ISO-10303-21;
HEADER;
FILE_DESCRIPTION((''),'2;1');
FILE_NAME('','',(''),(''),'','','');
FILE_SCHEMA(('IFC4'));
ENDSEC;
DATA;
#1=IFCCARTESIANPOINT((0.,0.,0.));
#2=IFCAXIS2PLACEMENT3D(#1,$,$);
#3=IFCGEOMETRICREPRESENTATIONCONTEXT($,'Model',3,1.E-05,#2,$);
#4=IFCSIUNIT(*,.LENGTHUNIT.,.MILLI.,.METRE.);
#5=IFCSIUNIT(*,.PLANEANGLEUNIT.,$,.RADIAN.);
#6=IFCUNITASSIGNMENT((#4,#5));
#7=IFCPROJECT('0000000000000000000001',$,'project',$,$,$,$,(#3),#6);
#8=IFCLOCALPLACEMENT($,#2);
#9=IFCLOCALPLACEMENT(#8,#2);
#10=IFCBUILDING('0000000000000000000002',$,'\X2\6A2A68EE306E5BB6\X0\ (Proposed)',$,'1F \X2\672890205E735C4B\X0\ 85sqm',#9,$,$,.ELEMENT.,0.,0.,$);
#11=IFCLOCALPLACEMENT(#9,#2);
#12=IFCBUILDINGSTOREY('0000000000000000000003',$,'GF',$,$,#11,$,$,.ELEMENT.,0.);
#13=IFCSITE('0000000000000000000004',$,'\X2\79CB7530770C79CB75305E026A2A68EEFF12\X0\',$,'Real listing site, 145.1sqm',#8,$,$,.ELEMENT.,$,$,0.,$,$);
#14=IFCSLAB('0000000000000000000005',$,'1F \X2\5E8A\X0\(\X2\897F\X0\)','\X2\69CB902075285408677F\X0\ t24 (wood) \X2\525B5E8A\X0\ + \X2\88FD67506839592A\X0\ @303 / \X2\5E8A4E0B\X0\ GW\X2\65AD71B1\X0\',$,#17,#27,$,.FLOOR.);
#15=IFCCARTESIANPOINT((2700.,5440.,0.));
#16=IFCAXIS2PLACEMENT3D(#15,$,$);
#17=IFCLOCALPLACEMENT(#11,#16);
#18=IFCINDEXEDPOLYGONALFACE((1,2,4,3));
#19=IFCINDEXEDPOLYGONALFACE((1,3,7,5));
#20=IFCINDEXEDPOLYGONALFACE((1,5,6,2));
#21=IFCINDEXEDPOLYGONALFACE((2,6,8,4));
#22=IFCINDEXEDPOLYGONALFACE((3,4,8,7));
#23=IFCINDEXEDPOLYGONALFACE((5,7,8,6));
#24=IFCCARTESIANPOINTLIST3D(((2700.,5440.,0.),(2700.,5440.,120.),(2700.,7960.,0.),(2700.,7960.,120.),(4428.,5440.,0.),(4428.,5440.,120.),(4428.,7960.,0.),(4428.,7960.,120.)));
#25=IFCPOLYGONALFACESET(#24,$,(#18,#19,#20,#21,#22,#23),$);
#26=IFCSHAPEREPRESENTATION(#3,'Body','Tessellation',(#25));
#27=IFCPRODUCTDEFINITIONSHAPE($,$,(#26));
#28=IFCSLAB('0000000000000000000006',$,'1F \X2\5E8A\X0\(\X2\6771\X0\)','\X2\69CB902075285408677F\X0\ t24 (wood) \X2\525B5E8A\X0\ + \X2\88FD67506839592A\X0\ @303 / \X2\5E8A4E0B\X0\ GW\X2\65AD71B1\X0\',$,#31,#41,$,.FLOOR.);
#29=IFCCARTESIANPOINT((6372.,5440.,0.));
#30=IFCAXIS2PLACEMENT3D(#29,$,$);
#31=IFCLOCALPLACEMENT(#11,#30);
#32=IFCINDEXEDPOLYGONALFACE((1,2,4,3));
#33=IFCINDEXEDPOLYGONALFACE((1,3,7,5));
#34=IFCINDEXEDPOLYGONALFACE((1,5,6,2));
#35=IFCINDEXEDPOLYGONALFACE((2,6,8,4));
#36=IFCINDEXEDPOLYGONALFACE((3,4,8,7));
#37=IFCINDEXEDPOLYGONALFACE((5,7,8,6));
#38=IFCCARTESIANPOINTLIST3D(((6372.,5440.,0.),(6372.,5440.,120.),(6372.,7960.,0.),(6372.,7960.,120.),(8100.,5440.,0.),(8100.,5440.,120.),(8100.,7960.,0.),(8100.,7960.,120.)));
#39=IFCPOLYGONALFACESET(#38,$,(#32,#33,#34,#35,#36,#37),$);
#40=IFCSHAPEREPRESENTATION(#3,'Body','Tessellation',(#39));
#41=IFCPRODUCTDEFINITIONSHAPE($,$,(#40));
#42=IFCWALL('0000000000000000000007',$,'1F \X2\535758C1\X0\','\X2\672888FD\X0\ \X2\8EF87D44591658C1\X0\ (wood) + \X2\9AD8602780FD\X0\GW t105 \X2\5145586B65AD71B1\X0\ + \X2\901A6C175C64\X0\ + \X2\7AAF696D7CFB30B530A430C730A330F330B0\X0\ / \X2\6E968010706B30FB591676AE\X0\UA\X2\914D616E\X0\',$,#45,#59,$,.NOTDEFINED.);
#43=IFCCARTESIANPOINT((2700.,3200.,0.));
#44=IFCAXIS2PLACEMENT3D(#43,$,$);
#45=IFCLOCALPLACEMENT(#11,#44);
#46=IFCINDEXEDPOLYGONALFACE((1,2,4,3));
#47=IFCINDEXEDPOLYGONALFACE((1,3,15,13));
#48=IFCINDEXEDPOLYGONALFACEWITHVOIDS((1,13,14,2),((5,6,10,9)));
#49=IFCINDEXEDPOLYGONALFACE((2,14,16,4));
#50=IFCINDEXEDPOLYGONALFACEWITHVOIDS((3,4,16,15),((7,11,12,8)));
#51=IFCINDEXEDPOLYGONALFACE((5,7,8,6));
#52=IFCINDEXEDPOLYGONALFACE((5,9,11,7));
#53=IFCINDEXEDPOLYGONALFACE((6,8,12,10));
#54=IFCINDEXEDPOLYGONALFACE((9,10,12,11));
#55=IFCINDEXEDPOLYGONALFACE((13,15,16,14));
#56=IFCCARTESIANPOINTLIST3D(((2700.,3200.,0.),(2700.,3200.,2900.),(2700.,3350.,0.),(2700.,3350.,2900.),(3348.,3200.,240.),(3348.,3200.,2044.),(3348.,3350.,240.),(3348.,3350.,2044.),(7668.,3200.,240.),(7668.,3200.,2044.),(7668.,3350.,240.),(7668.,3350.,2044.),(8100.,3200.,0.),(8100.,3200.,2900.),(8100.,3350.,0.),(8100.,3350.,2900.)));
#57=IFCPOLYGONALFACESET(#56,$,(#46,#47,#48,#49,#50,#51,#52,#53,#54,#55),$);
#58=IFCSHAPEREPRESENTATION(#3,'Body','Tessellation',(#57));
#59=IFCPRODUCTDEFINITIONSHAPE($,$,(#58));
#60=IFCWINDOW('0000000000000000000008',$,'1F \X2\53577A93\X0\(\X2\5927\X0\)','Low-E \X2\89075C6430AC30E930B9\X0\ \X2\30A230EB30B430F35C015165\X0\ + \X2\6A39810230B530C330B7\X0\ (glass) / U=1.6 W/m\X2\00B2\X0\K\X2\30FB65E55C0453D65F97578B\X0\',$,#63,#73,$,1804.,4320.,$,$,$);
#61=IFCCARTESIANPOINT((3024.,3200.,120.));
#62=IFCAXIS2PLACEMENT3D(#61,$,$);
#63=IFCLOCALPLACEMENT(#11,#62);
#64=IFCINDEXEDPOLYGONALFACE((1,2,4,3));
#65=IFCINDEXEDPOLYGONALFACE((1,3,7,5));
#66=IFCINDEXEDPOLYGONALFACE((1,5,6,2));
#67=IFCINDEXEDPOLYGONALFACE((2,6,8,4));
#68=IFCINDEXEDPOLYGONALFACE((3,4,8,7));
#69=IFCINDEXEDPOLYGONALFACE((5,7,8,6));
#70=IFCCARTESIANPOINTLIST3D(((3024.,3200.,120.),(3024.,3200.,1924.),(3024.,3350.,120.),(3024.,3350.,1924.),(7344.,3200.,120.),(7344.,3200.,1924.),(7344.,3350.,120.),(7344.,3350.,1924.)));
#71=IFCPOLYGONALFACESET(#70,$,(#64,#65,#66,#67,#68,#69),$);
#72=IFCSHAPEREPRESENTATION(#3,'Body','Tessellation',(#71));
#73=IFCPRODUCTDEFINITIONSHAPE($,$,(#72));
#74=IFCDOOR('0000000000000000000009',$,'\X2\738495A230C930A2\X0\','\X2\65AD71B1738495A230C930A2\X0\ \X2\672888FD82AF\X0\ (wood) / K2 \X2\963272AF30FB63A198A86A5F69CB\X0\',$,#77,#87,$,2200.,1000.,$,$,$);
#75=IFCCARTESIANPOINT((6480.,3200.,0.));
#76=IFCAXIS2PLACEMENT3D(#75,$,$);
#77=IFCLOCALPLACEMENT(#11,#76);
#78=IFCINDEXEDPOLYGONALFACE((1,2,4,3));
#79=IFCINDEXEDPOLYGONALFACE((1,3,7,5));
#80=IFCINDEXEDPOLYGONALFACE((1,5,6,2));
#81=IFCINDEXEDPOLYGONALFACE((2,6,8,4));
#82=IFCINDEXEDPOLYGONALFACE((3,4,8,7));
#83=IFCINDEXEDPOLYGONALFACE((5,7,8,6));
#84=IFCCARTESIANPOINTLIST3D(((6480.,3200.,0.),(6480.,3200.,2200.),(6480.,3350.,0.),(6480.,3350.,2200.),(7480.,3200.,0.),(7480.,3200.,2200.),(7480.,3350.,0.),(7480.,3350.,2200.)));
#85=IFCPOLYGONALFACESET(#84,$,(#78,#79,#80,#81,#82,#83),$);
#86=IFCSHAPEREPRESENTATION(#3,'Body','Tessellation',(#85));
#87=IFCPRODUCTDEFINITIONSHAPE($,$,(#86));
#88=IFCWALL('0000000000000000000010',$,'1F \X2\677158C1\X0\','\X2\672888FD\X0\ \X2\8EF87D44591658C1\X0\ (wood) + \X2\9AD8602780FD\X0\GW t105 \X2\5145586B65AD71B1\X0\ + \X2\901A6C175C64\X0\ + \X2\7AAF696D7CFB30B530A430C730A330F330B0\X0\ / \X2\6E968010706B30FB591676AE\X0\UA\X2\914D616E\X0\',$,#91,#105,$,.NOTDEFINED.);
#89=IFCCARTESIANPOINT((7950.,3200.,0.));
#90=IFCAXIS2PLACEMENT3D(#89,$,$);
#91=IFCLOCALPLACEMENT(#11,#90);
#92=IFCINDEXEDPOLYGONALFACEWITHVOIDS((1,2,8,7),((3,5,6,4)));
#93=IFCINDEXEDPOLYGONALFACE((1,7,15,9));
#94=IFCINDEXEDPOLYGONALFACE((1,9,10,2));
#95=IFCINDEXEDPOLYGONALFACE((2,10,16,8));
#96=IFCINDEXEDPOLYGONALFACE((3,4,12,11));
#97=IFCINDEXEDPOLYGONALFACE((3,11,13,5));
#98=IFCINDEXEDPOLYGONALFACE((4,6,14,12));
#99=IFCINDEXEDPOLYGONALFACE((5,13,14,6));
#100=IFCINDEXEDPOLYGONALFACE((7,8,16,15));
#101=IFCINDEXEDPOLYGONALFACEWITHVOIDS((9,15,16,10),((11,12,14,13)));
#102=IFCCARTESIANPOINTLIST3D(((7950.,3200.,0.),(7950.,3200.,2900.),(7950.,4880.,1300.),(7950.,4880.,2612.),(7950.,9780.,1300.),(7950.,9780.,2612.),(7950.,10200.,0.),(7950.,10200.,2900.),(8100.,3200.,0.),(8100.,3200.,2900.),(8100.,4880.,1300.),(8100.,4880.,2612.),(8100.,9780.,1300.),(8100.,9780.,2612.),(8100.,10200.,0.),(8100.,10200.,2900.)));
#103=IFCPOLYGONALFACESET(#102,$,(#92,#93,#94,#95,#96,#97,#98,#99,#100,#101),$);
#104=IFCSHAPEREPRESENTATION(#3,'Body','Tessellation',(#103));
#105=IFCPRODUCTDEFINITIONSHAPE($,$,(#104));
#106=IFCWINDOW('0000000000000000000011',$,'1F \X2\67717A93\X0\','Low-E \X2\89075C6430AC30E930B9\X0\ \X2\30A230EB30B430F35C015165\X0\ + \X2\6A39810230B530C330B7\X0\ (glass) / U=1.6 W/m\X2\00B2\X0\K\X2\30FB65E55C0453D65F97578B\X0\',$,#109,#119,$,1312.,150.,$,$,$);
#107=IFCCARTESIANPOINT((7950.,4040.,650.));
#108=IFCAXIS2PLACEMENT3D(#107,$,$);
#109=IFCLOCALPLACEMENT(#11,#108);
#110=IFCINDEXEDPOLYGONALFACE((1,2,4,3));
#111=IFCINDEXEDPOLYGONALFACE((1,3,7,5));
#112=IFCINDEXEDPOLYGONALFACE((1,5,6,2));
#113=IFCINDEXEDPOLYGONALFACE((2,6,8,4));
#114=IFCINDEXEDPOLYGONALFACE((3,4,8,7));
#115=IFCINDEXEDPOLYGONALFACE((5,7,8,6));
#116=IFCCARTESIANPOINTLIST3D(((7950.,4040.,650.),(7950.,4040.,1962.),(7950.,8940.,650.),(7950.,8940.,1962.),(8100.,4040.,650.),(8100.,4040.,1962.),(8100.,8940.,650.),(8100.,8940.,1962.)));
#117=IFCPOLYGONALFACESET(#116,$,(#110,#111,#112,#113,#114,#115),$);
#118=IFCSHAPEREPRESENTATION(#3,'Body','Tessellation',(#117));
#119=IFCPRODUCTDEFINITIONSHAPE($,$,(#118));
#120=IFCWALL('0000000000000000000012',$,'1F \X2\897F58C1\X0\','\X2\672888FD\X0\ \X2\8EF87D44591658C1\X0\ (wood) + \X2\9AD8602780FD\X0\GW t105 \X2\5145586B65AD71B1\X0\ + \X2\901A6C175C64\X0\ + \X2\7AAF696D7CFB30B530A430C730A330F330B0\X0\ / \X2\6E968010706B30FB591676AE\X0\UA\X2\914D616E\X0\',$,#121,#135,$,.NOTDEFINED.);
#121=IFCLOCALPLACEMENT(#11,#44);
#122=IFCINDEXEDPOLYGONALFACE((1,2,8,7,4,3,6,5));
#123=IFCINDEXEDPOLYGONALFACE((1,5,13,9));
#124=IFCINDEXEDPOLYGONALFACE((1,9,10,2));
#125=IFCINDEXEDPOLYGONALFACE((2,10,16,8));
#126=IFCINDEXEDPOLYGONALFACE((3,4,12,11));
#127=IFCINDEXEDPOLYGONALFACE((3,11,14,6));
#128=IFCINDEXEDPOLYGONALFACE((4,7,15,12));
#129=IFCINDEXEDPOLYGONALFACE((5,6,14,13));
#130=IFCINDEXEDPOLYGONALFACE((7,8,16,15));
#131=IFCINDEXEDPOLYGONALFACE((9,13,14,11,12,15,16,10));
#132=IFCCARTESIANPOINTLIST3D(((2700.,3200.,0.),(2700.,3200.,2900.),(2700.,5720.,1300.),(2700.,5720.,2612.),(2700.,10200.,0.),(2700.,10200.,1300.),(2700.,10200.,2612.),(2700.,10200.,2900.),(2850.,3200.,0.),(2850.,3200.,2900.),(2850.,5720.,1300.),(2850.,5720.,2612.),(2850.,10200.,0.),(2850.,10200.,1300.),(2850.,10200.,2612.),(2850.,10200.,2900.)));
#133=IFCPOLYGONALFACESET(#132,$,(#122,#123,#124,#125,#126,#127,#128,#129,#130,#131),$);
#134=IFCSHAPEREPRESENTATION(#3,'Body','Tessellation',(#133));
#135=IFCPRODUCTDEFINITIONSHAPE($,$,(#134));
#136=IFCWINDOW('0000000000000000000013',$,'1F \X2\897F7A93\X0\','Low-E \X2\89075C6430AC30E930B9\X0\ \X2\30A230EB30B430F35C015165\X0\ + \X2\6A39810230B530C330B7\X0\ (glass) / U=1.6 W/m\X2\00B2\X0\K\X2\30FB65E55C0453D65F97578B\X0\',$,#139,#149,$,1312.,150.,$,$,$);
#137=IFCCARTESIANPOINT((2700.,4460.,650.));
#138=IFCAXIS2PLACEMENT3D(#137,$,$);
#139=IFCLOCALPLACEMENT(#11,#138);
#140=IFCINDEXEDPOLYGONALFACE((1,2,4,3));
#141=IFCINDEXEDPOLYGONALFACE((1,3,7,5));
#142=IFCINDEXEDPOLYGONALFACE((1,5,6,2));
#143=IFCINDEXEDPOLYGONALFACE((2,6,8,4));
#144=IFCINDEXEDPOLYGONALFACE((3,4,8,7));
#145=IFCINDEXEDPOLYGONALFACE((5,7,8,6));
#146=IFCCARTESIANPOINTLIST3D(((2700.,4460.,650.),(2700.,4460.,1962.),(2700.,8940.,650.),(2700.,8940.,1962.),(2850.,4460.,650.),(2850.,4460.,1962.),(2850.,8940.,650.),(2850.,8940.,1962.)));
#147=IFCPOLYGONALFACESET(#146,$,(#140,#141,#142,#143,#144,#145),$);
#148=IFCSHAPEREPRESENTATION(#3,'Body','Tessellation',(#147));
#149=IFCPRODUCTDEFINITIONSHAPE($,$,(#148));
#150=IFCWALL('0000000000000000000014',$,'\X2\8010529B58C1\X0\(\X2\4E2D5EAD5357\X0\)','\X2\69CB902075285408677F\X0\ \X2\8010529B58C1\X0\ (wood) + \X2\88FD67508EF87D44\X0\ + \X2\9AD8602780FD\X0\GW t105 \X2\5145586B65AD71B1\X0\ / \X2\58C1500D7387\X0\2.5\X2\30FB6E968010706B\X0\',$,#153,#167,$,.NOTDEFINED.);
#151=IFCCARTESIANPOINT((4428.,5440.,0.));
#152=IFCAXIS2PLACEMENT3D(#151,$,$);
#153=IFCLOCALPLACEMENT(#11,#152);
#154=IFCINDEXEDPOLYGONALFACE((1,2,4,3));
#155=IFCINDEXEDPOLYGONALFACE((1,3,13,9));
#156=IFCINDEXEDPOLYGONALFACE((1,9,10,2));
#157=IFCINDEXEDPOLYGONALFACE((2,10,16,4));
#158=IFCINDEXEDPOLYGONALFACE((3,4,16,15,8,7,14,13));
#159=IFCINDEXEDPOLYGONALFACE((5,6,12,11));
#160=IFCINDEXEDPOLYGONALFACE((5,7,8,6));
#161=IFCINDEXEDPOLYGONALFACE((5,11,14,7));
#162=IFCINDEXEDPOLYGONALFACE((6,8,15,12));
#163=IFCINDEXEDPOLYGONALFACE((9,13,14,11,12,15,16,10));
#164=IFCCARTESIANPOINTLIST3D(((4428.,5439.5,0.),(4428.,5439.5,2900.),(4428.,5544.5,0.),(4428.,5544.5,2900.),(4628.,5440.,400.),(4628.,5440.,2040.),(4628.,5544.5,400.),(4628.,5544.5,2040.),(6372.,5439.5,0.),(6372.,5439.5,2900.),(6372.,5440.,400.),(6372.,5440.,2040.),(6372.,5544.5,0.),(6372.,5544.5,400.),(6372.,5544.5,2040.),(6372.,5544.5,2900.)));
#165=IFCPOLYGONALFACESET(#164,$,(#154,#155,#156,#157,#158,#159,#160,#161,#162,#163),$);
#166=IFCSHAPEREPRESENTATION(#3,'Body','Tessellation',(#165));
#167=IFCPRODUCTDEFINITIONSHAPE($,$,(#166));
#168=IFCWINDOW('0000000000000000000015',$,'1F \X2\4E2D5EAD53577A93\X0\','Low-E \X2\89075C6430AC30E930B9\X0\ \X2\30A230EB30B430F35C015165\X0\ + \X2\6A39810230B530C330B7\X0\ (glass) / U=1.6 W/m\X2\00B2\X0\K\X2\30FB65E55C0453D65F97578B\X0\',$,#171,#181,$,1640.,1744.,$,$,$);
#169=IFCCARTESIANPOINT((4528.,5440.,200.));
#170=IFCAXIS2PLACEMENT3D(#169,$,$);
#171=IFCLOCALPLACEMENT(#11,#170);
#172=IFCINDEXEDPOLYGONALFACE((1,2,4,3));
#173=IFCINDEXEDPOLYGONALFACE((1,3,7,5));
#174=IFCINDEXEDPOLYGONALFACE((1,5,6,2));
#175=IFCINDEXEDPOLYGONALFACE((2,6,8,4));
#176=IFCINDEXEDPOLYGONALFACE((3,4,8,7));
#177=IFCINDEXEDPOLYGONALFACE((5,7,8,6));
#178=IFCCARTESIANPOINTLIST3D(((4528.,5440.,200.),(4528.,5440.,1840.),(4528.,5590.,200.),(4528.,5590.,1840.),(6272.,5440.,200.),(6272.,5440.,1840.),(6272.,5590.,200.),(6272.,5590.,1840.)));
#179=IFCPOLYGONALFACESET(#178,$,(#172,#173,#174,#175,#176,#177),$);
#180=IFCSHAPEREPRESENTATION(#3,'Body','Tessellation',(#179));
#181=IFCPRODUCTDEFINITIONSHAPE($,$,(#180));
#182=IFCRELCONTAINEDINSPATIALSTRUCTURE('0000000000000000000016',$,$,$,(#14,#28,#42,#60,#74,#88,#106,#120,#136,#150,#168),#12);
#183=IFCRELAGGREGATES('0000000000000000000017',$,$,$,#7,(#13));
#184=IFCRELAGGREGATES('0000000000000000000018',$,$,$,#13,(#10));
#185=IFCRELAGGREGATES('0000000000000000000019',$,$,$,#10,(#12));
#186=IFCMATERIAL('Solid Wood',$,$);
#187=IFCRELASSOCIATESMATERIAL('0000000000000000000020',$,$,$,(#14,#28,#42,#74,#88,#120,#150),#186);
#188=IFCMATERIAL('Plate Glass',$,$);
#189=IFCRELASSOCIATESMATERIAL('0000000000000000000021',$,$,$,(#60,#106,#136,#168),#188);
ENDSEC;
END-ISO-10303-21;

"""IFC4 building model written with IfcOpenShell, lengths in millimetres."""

from ifc_helpers import new_model, si_unit, frame, frame_2d, origin, place, context, project, spatial, rectangle, extrude, material, element, fill, save


model = new_model("IFC4")

# Units and contexts
model_context = context("Model", 3, precision=1e-05, world=origin())
ifc_project = project(units=[si_unit("LENGTHUNIT", "METRE", prefix="MILLI"), si_unit("PLANEANGLEUNIT", "RADIAN")], contexts=[model_context])

# Site, building, storey
site_placement = place(None, origin())
site = spatial("IfcSite", under=ifc_project, at=site_placement, Name="秋田県秋田市横森２", ObjectType="Real listing site, 145.1sqm", CompositionType="ELEMENT", RefElevation=0.0)
building_placement = place(site_placement, origin())
building = spatial("IfcBuilding", under=site, at=building_placement, Name="横森の家 (Proposed)", ObjectType="1F 木造平屋 85sqm", CompositionType="ELEMENT", ElevationOfRefHeight=0.0, ElevationOfTerrain=0.0)
storey_placement = place(building_placement, origin())
storey = spatial("IfcBuildingStorey", under=building, at=storey_placement, Name="GF", CompositionType="ELEMENT", Elevation=0.0)

# Slabs
ifc_material_1 = material(Name="Solid Wood")
slab_1_placement = place(storey_placement, frame((2700.0, 5440.0, 0.0)))
element("IfcSlab", 1, at=slab_1_placement, inside=storey, material=ifc_material_1, Name="1F 床(西)", Description="構造用合板 t24 (wood) 剛床 + 製材根太 @303 / 床下 GW断熱", PredefinedType="FLOOR", context=model_context, shape_type="SweptSolid", body=[
    extrude(rectangle(XDim=1728.0, YDim=2520.0, at=frame_2d((864.0, 1260.0))), frame((2700.0, 5440.0, 0.0)), (0.0, 0.0, 1.0), 120.0),
])
slab_2_placement = place(storey_placement, frame((6372.0, 5440.0, 0.0)))
element("IfcSlab", 2, at=slab_2_placement, inside=storey, material=ifc_material_1, Name="1F 床(東)", Description="構造用合板 t24 (wood) 剛床 + 製材根太 @303 / 床下 GW断熱", PredefinedType="FLOOR", context=model_context, shape_type="SweptSolid", body=[
    extrude(rectangle(XDim=1728.0, YDim=2520.0, at=frame_2d((864.0, 1260.0))), frame((6372.0, 5440.0, 0.0)), (0.0, 0.0, 1.0), 120.0),
])

# Wall, openings, window, door
wall_1_placement = place(storey_placement, frame((2700.0, 3200.0, 0.0)))
wall_1 = element("IfcWall", 3, at=wall_1_placement, inside=storey, material=ifc_material_1, Name="1F 南壁", Description="木製 軸組外壁 (wood) + 高性能GW t105 充填断熱 + 通気層 + 窯業系サイディング / 準耐火・外皮UA配慮", PredefinedType="NOTDEFINED", context=model_context, shape_type="SweptSolid", body=[
    extrude(rectangle(XDim=5400.0, YDim=150.0, at=frame_2d((2700.0, 75.0))), frame((2700.0, 3200.0, 0.0)), (0.0, 0.0, 1.0), 2900.0),
])
opening_1_placement = place(storey_placement, frame((3024.0, 3200.0, 120.0)))
opening_1 = element("IfcOpeningElement", 4, at=opening_1_placement, cuts=wall_1, PredefinedType="NOTDEFINED", context=model_context, shape_type="SweptSolid", body=[
    extrude(rectangle(XDim=4320.0, YDim=150.0, at=frame_2d((2160.0, 75.0))), frame((3024.0, 3200.0, 120.0)), (0.0, 0.0, 1.0), 1804.0),
])
opening_2_placement = place(storey_placement, frame((6480.0, 3200.0, 0.0)))
opening_2 = element("IfcOpeningElement", 5, at=opening_2_placement, cuts=wall_1, PredefinedType="NOTDEFINED", context=model_context, shape_type="SweptSolid", body=[
    extrude(rectangle(XDim=1000.0, YDim=150.0, at=frame_2d((500.0, 75.0))), frame((6480.0, 3200.0, 0.0)), (0.0, 0.0, 1.0), 2200.0),
])
ifc_material_2 = material(Name="Plate Glass")
window_1_placement = place(storey_placement, frame((3024.0, 3200.0, 120.0)))
window_1 = element("IfcWindow", 6, at=window_1_placement, inside=storey, material=ifc_material_2, Name="1F 南窓(大)", Description="Low-E 複層ガラス アルゴン封入 + 樹脂サッシ (glass) / U=1.6 W/m²K・日射取得型", OverallHeight=1804.0, OverallWidth=4320.0, context=model_context, shape_type="SweptSolid", body=[
    extrude(rectangle(XDim=4320.0, YDim=150.0, at=frame_2d((2160.0, 75.0))), frame((3024.0, 3200.0, 120.0)), (0.0, 0.0, 1.0), 1804.0),
])
fill(opening_1, window_1)
door_placement = place(storey_placement, frame((6480.0, 3200.0, 0.0)))
door = element("IfcDoor", 7, at=door_placement, inside=storey, material=ifc_material_1, Name="玄関ドア", Description="断熱玄関ドア 木製芯 (wood) / K2 防犯・採風機構", OverallHeight=2200.0, OverallWidth=1000.0, context=model_context, shape_type="SweptSolid", body=[
    extrude(rectangle(XDim=1000.0, YDim=150.0, at=frame_2d((500.0, 75.0))), frame((6480.0, 3200.0, 0.0)), (0.0, 0.0, 1.0), 2200.0),
])
fill(opening_2, door)

# Walls, openings, windows
wall_2_placement = place(storey_placement, frame((7950.0, 3200.0, 0.0)))
wall_2 = element("IfcWall", 8, at=wall_2_placement, inside=storey, material=ifc_material_1, Name="1F 東壁", Description="木製 軸組外壁 (wood) + 高性能GW t105 充填断熱 + 通気層 + 窯業系サイディング / 準耐火・外皮UA配慮", PredefinedType="NOTDEFINED", context=model_context, shape_type="SweptSolid", body=[
    extrude(rectangle(XDim=150.0, YDim=7000.0, at=frame_2d((75.0, 3500.0))), frame((7950.0, 3200.0, 0.0)), (0.0, 0.0, 1.0), 2900.0),
])
opening_3_placement = place(storey_placement, frame((7950.0, 4040.0, 650.0)))
opening_3 = element("IfcOpeningElement", 9, at=opening_3_placement, cuts=wall_2, PredefinedType="NOTDEFINED", context=model_context, shape_type="SweptSolid", body=[
    extrude(rectangle(XDim=150.0, YDim=4900.0, at=frame_2d((75.0, 2450.0))), frame((7950.0, 4040.0, 650.0)), (0.0, 0.0, 1.0), 1312.0),
])
window_2_placement = place(storey_placement, frame((7950.0, 4040.0, 650.0)))
window_2 = element("IfcWindow", 10, at=window_2_placement, inside=storey, material=ifc_material_2, Name="1F 東窓", Description="Low-E 複層ガラス アルゴン封入 + 樹脂サッシ (glass) / U=1.6 W/m²K・日射取得型", OverallHeight=1312.0, OverallWidth=150.0, context=model_context, shape_type="SweptSolid", body=[
    extrude(rectangle(XDim=150.0, YDim=4900.0, at=frame_2d((75.0, 2450.0))), frame((7950.0, 4040.0, 650.0)), (0.0, 0.0, 1.0), 1312.0),
])
fill(opening_3, window_2)
wall_3_placement = place(storey_placement, frame((2700.0, 3200.0, 0.0)))
wall_3 = element("IfcWall", 11, at=wall_3_placement, inside=storey, material=ifc_material_1, Name="1F 西壁", Description="木製 軸組外壁 (wood) + 高性能GW t105 充填断熱 + 通気層 + 窯業系サイディング / 準耐火・外皮UA配慮", PredefinedType="NOTDEFINED", context=model_context, shape_type="SweptSolid", body=[
    extrude(rectangle(XDim=150.0, YDim=7000.0, at=frame_2d((75.0, 3500.0))), frame((2700.0, 3200.0, 0.0)), (0.0, 0.0, 1.0), 2900.0),
])
opening_4_placement = place(storey_placement, frame((2700.0, 4460.0, 650.0)))
opening_4 = element("IfcOpeningElement", 12, at=opening_4_placement, cuts=wall_3, PredefinedType="NOTDEFINED", context=model_context, shape_type="SweptSolid", body=[
    extrude(rectangle(XDim=150.0, YDim=4480.0, at=frame_2d((75.0, 2240.0))), frame((2700.0, 4460.0, 650.0)), (0.0, 0.0, 1.0), 1312.0),
])
window_3_placement = place(storey_placement, frame((2700.0, 4460.0, 650.0)))
window_3 = element("IfcWindow", 13, at=window_3_placement, inside=storey, material=ifc_material_2, Name="1F 西窓", Description="Low-E 複層ガラス アルゴン封入 + 樹脂サッシ (glass) / U=1.6 W/m²K・日射取得型", OverallHeight=1312.0, OverallWidth=150.0, context=model_context, shape_type="SweptSolid", body=[
    extrude(rectangle(XDim=150.0, YDim=4480.0, at=frame_2d((75.0, 2240.0))), frame((2700.0, 4460.0, 650.0)), (0.0, 0.0, 1.0), 1312.0),
])
fill(opening_4, window_3)
wall_4_placement = place(storey_placement, frame((4428.0, 5440.0, 0.0)))
wall_4 = element("IfcWall", 14, at=wall_4_placement, inside=storey, material=ifc_material_1, Name="耐力壁(中庭南)", Description="構造用合板 耐力壁 (wood) + 製材軸組 + 高性能GW t105 充填断熱 / 壁倍率2.5・準耐火", PredefinedType="NOTDEFINED", context=model_context, shape_type="SweptSolid", body=[
    extrude(rectangle(XDim=1944.0, YDim=105.0, at=frame_2d((972.0, 52.0))), frame((4428.0, 5440.0, 0.0)), (0.0, 0.0, 1.0), 2900.0),
])
opening_5_placement = place(storey_placement, frame((4528.0, 5440.0, 200.0)))
opening_5 = element("IfcOpeningElement", 15, at=opening_5_placement, cuts=wall_4, PredefinedType="NOTDEFINED", context=model_context, shape_type="SweptSolid", body=[
    extrude(rectangle(XDim=1744.0, YDim=150.0, at=frame_2d((872.0, 75.0))), frame((4528.0, 5440.0, 200.0)), (0.0, 0.0, 1.0), 1640.0),
])
window_4_placement = place(storey_placement, frame((4528.0, 5440.0, 200.0)))
window_4 = element("IfcWindow", 16, at=window_4_placement, inside=storey, material=ifc_material_2, Name="1F 中庭南窓", Description="Low-E 複層ガラス アルゴン封入 + 樹脂サッシ (glass) / U=1.6 W/m²K・日射取得型", OverallHeight=1640.0, OverallWidth=1744.0, context=model_context, shape_type="SweptSolid", body=[
    extrude(rectangle(XDim=1744.0, YDim=150.0, at=frame_2d((872.0, 75.0))), frame((4528.0, 5440.0, 200.0)), (0.0, 0.0, 1.0), 1640.0),
])
fill(opening_5, window_4)

save(model, "model.ifc")
